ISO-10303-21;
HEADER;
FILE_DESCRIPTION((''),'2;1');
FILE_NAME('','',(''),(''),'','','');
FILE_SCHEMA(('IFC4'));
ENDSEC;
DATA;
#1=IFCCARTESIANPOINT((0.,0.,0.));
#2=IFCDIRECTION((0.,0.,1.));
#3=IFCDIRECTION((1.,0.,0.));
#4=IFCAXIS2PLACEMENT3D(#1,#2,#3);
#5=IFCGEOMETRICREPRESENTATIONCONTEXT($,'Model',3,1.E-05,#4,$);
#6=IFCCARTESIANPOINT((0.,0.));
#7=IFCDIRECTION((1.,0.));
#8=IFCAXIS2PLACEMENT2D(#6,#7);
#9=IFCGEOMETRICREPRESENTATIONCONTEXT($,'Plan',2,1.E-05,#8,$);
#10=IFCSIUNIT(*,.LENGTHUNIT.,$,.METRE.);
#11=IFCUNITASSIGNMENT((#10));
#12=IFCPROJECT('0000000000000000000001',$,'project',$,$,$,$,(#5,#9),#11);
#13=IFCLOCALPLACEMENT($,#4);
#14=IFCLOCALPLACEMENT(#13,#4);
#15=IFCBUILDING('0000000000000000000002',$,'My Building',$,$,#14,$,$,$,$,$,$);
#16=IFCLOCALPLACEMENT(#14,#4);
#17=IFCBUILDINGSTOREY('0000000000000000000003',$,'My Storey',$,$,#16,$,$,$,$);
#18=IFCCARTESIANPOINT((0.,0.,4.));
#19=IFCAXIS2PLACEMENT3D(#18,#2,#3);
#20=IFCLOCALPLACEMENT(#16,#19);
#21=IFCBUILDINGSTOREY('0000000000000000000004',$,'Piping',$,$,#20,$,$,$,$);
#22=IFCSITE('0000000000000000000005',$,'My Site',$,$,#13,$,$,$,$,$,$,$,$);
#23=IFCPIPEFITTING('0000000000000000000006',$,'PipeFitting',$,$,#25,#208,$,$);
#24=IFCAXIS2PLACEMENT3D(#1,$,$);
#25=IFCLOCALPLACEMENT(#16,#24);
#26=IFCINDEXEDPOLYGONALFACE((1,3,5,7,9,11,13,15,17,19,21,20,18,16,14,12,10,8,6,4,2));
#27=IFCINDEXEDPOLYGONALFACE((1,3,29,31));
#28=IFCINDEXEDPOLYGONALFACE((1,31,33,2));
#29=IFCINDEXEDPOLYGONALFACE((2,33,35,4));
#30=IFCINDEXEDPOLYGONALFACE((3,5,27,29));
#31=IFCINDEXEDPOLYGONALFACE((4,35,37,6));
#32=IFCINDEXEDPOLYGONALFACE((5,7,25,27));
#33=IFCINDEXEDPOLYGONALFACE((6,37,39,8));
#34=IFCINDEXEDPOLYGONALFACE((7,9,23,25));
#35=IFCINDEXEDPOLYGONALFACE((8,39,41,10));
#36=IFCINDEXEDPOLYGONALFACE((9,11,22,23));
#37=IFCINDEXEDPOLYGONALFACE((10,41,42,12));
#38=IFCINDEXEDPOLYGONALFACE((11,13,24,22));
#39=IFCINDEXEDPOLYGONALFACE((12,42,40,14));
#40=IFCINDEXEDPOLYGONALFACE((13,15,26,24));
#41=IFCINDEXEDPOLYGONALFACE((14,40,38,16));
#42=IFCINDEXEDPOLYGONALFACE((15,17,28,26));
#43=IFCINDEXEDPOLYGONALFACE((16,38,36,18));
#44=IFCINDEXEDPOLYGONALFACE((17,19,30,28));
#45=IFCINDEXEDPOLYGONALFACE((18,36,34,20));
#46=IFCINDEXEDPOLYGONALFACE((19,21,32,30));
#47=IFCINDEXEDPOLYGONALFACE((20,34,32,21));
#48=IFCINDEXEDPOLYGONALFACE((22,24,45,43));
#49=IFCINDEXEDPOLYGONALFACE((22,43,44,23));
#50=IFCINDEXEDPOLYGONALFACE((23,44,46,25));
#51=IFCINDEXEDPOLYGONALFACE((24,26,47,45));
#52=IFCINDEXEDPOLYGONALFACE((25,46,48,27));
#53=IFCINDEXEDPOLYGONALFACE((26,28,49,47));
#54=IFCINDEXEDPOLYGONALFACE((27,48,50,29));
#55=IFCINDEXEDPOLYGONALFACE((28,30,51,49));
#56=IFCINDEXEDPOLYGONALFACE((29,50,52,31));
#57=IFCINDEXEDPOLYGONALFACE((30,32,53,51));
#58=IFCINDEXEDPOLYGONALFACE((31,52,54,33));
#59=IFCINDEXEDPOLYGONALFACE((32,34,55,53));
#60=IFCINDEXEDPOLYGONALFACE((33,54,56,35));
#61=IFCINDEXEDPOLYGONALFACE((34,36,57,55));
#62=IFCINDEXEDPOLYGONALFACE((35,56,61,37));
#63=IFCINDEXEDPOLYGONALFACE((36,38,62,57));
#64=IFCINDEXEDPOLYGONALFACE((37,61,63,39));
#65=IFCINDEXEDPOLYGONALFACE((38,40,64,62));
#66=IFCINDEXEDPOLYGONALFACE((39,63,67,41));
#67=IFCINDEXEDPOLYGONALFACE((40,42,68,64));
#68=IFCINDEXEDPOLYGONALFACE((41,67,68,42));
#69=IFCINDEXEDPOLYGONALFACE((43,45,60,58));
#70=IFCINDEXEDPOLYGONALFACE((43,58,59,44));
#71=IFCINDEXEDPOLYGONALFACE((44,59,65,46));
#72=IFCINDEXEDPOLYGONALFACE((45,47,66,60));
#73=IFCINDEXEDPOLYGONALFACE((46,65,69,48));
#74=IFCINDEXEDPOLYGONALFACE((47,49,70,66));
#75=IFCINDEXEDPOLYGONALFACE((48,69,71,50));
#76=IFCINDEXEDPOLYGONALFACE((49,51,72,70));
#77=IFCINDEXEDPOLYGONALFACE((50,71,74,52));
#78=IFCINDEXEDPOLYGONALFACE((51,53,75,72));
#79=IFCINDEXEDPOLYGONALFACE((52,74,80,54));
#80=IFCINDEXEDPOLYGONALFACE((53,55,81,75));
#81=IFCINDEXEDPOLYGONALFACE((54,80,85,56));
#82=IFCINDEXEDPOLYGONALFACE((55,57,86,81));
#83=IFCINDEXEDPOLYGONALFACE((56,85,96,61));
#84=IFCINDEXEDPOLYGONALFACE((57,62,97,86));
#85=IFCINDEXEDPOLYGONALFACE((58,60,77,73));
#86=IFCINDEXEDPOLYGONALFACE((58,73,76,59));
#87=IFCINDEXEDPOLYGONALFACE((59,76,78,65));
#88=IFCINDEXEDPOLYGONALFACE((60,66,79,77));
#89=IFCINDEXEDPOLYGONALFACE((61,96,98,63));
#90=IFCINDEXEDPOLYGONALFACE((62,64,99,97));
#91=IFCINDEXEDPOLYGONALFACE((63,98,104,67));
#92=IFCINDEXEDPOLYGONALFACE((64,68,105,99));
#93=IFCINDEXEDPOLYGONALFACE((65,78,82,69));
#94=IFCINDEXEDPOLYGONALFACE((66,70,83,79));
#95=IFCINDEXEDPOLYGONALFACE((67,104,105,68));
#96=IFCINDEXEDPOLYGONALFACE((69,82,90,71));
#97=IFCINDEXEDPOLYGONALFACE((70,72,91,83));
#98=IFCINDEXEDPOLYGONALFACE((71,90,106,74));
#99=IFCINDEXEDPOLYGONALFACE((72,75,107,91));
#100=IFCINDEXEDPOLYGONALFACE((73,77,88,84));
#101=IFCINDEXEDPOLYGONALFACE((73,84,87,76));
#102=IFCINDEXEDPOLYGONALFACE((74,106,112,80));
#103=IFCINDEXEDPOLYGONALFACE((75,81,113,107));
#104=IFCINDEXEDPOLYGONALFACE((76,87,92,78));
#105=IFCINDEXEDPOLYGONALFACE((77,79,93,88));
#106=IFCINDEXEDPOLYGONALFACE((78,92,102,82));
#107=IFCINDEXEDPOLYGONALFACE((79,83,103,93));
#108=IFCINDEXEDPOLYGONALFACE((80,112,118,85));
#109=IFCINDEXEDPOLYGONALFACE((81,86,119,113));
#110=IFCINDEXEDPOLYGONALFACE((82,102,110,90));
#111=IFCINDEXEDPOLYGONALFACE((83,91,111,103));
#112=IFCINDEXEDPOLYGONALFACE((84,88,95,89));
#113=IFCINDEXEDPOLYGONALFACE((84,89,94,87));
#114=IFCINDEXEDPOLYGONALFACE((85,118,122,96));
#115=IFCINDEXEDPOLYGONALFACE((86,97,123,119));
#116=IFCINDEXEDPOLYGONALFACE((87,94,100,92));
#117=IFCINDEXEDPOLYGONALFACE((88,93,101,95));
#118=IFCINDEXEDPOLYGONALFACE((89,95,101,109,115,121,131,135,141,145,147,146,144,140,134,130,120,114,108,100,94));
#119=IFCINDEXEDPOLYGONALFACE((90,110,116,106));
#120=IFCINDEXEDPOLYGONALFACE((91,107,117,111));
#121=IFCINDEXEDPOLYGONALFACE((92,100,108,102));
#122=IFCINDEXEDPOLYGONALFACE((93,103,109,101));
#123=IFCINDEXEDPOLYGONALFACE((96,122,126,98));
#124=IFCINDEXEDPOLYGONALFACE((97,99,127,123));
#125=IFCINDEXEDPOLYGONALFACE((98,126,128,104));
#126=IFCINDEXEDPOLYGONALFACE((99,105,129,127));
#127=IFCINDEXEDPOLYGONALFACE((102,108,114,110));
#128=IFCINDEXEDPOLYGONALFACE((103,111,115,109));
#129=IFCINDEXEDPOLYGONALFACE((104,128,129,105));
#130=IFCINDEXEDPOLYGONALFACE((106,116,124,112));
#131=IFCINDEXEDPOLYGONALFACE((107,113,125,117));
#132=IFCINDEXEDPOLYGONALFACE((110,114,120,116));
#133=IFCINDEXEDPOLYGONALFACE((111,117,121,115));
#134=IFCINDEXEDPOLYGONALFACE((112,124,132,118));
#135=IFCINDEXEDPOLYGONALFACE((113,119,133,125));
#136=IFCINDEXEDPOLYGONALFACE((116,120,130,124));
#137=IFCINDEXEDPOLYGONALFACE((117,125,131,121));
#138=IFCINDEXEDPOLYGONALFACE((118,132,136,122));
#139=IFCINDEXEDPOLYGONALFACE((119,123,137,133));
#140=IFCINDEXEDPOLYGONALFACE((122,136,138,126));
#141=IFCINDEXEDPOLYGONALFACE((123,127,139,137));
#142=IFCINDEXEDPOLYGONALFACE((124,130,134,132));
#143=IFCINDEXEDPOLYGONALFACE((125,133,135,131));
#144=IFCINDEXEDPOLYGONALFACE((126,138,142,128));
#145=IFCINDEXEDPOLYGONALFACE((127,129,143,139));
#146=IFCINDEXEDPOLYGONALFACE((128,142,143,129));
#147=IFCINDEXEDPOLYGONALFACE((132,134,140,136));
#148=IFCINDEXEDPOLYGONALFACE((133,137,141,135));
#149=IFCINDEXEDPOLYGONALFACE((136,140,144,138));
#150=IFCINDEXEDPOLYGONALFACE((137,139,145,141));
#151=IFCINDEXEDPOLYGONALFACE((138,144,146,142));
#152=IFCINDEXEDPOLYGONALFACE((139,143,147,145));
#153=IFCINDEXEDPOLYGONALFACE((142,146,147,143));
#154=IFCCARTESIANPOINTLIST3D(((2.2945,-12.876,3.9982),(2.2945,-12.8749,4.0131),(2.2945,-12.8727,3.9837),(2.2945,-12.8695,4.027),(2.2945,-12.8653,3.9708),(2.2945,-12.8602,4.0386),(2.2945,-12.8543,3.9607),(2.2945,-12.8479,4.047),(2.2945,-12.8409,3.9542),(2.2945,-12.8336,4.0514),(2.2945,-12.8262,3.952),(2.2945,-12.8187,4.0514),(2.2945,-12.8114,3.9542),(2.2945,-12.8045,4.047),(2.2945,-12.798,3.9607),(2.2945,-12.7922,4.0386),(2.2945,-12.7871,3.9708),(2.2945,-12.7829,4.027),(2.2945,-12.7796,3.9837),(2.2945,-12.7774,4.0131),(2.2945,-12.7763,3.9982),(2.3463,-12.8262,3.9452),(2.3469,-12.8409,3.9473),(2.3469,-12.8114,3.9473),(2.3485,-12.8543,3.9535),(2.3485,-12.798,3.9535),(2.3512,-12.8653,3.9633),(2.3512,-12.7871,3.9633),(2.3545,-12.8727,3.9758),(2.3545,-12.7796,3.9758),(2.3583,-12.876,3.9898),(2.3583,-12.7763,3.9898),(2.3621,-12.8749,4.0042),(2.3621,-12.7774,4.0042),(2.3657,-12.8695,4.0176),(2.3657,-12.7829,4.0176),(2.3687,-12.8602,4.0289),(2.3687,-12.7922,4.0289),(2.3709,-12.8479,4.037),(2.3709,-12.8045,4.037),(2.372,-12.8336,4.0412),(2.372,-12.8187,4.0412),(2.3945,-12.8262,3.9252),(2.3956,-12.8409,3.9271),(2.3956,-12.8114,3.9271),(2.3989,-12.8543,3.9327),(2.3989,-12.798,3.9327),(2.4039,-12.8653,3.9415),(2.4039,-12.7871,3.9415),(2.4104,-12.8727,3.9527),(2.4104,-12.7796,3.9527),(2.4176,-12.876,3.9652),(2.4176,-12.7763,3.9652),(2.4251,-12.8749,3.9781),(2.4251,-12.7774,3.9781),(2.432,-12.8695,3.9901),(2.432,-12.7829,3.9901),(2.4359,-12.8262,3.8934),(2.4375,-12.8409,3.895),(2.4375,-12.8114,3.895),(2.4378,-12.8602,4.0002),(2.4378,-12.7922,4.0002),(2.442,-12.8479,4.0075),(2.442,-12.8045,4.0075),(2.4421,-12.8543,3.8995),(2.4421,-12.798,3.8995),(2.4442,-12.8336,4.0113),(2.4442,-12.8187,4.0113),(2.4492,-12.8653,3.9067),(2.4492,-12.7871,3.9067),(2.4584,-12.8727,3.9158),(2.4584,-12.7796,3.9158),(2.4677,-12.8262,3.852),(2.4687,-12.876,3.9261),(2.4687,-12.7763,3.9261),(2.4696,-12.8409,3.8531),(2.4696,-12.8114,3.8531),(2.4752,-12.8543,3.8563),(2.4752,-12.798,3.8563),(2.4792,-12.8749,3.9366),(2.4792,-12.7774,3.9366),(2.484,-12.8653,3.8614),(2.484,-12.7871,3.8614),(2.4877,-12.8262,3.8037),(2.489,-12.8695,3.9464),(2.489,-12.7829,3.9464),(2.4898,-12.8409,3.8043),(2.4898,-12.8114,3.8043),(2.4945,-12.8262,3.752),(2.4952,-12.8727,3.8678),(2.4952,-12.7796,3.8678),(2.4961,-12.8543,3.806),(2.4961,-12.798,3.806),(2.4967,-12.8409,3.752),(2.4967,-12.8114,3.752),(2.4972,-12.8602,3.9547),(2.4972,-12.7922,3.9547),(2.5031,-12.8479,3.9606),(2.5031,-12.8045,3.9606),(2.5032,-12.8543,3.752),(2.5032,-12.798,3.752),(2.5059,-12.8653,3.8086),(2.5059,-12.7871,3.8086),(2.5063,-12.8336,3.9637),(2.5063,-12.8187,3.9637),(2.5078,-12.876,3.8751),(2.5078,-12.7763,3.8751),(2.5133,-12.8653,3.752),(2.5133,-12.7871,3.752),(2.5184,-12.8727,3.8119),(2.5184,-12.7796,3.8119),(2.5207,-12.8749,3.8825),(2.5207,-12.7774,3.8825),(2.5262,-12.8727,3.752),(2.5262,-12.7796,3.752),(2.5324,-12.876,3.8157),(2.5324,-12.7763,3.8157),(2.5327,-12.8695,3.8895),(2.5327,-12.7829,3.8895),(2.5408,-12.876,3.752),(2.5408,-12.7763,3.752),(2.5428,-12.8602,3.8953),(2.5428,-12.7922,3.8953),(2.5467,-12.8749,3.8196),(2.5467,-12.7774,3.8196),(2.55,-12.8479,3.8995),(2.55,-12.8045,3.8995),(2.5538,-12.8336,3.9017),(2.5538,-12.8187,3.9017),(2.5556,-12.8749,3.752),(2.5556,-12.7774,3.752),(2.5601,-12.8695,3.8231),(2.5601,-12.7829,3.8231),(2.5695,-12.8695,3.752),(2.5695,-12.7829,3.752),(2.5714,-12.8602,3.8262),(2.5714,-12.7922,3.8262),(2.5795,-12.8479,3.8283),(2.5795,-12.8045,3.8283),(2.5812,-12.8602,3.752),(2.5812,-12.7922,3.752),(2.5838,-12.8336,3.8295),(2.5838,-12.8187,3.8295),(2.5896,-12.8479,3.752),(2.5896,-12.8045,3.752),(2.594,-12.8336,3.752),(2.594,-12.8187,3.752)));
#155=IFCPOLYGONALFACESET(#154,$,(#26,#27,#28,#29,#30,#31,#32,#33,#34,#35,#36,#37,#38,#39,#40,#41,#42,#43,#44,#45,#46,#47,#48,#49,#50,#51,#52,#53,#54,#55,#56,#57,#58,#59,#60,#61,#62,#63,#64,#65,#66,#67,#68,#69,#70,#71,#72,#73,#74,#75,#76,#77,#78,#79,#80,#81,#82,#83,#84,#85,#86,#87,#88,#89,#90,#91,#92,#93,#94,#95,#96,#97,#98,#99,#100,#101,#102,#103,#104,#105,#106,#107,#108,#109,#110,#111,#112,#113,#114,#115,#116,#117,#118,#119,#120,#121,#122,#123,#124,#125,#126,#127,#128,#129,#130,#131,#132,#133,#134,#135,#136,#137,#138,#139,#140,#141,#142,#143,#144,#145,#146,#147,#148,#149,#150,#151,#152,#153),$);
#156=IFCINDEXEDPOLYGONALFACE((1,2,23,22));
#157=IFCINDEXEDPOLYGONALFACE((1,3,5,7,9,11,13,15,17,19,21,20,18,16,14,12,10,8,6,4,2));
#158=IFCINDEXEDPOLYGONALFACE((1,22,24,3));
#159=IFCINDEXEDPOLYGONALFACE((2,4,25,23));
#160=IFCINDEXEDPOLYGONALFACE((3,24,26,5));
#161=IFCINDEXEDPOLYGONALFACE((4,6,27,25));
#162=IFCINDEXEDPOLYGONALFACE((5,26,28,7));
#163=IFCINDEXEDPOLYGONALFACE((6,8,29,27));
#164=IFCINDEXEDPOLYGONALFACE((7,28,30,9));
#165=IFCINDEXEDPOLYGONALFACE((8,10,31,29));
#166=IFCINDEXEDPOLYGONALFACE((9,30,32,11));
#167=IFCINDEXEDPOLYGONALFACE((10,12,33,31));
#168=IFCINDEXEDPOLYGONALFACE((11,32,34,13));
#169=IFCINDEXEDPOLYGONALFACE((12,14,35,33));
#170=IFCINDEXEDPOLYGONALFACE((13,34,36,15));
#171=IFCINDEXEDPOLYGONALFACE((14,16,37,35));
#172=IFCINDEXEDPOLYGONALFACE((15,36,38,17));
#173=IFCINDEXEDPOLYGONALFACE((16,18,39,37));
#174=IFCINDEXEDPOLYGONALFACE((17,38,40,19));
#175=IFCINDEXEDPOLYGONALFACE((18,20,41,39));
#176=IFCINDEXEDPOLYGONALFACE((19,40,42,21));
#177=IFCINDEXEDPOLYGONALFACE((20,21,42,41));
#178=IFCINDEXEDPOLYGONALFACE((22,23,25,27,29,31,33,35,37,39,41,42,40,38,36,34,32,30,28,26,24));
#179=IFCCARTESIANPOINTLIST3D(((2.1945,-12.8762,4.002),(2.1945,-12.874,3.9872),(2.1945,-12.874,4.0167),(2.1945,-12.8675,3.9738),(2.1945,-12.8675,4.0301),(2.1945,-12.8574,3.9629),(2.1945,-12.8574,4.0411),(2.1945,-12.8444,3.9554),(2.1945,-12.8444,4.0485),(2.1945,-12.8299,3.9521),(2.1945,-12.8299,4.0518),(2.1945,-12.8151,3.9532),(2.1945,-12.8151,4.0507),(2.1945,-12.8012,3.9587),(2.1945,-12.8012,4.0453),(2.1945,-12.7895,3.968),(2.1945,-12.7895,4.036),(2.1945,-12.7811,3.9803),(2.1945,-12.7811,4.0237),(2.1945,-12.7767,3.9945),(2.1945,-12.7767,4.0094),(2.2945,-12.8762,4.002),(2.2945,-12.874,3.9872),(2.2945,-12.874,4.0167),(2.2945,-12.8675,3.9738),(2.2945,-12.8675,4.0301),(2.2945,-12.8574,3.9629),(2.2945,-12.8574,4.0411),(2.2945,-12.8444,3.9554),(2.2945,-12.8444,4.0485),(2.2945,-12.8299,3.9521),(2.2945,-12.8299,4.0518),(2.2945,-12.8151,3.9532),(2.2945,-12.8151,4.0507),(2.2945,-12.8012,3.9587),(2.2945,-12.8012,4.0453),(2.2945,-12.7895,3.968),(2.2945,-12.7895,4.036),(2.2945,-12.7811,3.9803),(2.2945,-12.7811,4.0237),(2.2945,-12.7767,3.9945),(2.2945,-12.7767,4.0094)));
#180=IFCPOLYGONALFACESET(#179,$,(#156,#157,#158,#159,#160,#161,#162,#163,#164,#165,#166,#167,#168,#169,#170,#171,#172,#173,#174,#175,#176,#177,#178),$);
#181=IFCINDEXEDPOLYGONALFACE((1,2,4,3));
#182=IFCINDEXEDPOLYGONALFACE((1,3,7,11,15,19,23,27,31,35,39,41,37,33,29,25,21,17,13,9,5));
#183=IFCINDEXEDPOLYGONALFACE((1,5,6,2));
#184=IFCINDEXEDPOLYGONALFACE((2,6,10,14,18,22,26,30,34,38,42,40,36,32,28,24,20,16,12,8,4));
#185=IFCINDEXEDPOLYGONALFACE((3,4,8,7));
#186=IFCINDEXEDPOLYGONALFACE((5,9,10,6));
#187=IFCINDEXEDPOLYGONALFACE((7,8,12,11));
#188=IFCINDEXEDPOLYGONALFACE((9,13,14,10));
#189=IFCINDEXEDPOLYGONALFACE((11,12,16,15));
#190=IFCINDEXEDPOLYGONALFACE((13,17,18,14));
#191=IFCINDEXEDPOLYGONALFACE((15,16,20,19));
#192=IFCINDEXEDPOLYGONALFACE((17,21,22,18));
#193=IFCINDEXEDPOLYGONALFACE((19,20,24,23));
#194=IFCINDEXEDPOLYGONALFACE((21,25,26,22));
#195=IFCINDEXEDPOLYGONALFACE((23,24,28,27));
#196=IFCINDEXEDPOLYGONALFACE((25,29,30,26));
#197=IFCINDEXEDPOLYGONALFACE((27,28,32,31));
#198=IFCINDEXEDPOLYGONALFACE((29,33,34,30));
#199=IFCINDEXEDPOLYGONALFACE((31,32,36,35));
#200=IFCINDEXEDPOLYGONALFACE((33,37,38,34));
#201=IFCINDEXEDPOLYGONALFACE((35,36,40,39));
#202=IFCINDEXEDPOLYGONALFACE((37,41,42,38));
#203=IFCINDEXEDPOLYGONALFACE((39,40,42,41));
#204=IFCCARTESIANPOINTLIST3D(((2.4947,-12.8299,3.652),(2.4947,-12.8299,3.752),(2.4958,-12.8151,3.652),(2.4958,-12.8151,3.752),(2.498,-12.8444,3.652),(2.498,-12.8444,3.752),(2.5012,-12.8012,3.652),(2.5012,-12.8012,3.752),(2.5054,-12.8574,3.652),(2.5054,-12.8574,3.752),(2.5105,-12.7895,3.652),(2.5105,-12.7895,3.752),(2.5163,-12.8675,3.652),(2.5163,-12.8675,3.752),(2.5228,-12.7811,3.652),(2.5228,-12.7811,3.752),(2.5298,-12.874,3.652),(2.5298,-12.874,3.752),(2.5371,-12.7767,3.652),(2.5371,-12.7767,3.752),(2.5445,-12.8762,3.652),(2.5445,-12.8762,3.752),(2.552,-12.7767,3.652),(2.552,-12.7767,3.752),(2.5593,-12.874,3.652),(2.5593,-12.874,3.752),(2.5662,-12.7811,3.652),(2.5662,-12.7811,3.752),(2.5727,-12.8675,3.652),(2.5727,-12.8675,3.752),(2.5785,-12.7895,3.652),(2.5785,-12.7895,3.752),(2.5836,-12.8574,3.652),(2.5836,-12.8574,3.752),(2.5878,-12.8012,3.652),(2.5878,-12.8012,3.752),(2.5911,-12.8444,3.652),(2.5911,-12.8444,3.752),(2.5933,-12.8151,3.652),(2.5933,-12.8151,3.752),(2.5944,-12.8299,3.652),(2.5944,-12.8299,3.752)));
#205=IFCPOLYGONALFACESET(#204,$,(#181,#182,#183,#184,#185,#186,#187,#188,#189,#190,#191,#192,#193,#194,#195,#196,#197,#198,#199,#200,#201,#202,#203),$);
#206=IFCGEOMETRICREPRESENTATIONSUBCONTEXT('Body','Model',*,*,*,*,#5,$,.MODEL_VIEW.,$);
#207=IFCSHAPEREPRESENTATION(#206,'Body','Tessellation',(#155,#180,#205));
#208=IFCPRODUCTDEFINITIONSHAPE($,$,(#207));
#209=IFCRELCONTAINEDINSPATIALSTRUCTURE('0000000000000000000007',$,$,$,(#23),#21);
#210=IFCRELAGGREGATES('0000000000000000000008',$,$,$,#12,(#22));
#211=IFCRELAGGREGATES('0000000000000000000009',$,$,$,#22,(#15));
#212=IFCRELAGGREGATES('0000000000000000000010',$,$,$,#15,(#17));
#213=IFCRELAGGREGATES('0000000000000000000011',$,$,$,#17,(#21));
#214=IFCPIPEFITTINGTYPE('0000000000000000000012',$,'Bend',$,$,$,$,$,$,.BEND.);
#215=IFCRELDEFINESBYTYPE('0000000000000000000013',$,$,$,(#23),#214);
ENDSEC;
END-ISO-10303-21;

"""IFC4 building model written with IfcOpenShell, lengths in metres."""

from ifc_helpers import new_model, entity, si_unit, frame, origin_with_axes, origin_2d_with_axis, place, context, subcontext, project, spatial, line, indexed_curve, circle, outline, extrude, source, transform, mapped, type_object, type_shapes, element, save


model = new_model("IFC4")

# Units and contexts
model_context = context("Model", 3, precision=1e-05, world=origin_with_axes())
plan_context = context("Plan", 2, precision=1e-05, world=origin_2d_with_axis())
body_context = subcontext(model_context, "Body", "Model", "MODEL_VIEW")
ifc_project = project(units=[si_unit("LENGTHUNIT", "METRE")], contexts=[model_context, plan_context])

# Site, building, storeys
site_placement = place(None, origin_with_axes())
site = spatial("IfcSite", under=ifc_project, at=site_placement, Name="My Site")
building_placement = place(site_placement, origin_with_axes())
building = spatial("IfcBuilding", under=site, at=building_placement, Name="My Building")
storey_1_placement = place(building_placement, origin_with_axes())
storey_1 = spatial("IfcBuildingStorey", under=building, at=storey_1_placement, Name="My Storey")
storey_2_placement = place(storey_1_placement, frame((0.0, 0.0, 4.0), z_axis=(0.0, 0.0, 1.0), x_axis=(1.0, 0.0, 0.0)))
storey_2 = spatial("IfcBuildingStorey", under=storey_1, at=storey_2_placement, Name="Piping")

# Shared definitions
pipe_fitting_type_1 = type_object("IfcPipeFittingType", Name="Bend", PredefinedType="BEND")
shared_shape = source(origin_with_axes(), body_context, "Body", "SolidModel", [
    entity("IfcSweptDiskSolid", entity("IfcIndexedPolyCurve", entity("IfcCartesianPointList3D", [[0.0, 0.0, -0.1], [0.0, -0.0732, -0.2768], [0.0, -0.25, -0.35]]), [entity("IfcArcIndex", [1, 2, 3])]), 0.05),
    extrude(circle(Radius=0.05), origin_with_axes(), (0.0, 0.0, -1.0), 0.1),
    extrude(circle(Radius=0.05), frame((0.0, -0.25, -0.35), z_axis=(0.0, -1.0, 0.0), x_axis=(1.0, 0.0, 0.0)), (0.0, 0.0, 1.0), 0.1),
])
type_shapes(pipe_fitting_type_1, [shared_shape])

# Pipe fitting, opening
pipe_fitting_1_placement = place(storey_2_placement, frame((2.1945, -12.8262, 0.002), z_axis=(-1.0, 0.0, -0.000001), x_axis=(0.0, -1.0, 0.0)))
pipe_fitting_1 = element("IfcPipeFitting", 1, at=pipe_fitting_1_placement, inside=storey_2, type_object=pipe_fitting_type_1, Name="PipeFitting", context=body_context, shape_type="MappedRepresentation", body=[
    mapped(shared_shape, transform((0.0, 0.0, 0.0), x_axis=(1.0, 0.0, 0.0), y_axis=(0.0, 1.0, 0.0), z_axis=(0.0, 0.0, 1.0), scale=1.0)),
])
opening_1_placement = place(pipe_fitting_1_placement, frame((-12.8262, -4.002, 2.1945), z_axis=(0.0, 1.0, -0.000001), x_axis=(0.0, -0.000001, -1.0)))
element("IfcOpeningElement", 2, at=opening_1_placement, cuts=pipe_fitting_1, PredefinedType="OPENING", context=body_context, shape_type="SweptSolid", body=[
    extrude(outline(indexed_curve([(0.0, 0.0), (0.5, 0.0), (0.5, 0.5), (0.0, 0.5)], segments=[line(1, 2, 3, 4, 1)])), origin_with_axes(), (0.0, 0.0, 1.0), 0.5),
])

save(model, "model.ifc")
